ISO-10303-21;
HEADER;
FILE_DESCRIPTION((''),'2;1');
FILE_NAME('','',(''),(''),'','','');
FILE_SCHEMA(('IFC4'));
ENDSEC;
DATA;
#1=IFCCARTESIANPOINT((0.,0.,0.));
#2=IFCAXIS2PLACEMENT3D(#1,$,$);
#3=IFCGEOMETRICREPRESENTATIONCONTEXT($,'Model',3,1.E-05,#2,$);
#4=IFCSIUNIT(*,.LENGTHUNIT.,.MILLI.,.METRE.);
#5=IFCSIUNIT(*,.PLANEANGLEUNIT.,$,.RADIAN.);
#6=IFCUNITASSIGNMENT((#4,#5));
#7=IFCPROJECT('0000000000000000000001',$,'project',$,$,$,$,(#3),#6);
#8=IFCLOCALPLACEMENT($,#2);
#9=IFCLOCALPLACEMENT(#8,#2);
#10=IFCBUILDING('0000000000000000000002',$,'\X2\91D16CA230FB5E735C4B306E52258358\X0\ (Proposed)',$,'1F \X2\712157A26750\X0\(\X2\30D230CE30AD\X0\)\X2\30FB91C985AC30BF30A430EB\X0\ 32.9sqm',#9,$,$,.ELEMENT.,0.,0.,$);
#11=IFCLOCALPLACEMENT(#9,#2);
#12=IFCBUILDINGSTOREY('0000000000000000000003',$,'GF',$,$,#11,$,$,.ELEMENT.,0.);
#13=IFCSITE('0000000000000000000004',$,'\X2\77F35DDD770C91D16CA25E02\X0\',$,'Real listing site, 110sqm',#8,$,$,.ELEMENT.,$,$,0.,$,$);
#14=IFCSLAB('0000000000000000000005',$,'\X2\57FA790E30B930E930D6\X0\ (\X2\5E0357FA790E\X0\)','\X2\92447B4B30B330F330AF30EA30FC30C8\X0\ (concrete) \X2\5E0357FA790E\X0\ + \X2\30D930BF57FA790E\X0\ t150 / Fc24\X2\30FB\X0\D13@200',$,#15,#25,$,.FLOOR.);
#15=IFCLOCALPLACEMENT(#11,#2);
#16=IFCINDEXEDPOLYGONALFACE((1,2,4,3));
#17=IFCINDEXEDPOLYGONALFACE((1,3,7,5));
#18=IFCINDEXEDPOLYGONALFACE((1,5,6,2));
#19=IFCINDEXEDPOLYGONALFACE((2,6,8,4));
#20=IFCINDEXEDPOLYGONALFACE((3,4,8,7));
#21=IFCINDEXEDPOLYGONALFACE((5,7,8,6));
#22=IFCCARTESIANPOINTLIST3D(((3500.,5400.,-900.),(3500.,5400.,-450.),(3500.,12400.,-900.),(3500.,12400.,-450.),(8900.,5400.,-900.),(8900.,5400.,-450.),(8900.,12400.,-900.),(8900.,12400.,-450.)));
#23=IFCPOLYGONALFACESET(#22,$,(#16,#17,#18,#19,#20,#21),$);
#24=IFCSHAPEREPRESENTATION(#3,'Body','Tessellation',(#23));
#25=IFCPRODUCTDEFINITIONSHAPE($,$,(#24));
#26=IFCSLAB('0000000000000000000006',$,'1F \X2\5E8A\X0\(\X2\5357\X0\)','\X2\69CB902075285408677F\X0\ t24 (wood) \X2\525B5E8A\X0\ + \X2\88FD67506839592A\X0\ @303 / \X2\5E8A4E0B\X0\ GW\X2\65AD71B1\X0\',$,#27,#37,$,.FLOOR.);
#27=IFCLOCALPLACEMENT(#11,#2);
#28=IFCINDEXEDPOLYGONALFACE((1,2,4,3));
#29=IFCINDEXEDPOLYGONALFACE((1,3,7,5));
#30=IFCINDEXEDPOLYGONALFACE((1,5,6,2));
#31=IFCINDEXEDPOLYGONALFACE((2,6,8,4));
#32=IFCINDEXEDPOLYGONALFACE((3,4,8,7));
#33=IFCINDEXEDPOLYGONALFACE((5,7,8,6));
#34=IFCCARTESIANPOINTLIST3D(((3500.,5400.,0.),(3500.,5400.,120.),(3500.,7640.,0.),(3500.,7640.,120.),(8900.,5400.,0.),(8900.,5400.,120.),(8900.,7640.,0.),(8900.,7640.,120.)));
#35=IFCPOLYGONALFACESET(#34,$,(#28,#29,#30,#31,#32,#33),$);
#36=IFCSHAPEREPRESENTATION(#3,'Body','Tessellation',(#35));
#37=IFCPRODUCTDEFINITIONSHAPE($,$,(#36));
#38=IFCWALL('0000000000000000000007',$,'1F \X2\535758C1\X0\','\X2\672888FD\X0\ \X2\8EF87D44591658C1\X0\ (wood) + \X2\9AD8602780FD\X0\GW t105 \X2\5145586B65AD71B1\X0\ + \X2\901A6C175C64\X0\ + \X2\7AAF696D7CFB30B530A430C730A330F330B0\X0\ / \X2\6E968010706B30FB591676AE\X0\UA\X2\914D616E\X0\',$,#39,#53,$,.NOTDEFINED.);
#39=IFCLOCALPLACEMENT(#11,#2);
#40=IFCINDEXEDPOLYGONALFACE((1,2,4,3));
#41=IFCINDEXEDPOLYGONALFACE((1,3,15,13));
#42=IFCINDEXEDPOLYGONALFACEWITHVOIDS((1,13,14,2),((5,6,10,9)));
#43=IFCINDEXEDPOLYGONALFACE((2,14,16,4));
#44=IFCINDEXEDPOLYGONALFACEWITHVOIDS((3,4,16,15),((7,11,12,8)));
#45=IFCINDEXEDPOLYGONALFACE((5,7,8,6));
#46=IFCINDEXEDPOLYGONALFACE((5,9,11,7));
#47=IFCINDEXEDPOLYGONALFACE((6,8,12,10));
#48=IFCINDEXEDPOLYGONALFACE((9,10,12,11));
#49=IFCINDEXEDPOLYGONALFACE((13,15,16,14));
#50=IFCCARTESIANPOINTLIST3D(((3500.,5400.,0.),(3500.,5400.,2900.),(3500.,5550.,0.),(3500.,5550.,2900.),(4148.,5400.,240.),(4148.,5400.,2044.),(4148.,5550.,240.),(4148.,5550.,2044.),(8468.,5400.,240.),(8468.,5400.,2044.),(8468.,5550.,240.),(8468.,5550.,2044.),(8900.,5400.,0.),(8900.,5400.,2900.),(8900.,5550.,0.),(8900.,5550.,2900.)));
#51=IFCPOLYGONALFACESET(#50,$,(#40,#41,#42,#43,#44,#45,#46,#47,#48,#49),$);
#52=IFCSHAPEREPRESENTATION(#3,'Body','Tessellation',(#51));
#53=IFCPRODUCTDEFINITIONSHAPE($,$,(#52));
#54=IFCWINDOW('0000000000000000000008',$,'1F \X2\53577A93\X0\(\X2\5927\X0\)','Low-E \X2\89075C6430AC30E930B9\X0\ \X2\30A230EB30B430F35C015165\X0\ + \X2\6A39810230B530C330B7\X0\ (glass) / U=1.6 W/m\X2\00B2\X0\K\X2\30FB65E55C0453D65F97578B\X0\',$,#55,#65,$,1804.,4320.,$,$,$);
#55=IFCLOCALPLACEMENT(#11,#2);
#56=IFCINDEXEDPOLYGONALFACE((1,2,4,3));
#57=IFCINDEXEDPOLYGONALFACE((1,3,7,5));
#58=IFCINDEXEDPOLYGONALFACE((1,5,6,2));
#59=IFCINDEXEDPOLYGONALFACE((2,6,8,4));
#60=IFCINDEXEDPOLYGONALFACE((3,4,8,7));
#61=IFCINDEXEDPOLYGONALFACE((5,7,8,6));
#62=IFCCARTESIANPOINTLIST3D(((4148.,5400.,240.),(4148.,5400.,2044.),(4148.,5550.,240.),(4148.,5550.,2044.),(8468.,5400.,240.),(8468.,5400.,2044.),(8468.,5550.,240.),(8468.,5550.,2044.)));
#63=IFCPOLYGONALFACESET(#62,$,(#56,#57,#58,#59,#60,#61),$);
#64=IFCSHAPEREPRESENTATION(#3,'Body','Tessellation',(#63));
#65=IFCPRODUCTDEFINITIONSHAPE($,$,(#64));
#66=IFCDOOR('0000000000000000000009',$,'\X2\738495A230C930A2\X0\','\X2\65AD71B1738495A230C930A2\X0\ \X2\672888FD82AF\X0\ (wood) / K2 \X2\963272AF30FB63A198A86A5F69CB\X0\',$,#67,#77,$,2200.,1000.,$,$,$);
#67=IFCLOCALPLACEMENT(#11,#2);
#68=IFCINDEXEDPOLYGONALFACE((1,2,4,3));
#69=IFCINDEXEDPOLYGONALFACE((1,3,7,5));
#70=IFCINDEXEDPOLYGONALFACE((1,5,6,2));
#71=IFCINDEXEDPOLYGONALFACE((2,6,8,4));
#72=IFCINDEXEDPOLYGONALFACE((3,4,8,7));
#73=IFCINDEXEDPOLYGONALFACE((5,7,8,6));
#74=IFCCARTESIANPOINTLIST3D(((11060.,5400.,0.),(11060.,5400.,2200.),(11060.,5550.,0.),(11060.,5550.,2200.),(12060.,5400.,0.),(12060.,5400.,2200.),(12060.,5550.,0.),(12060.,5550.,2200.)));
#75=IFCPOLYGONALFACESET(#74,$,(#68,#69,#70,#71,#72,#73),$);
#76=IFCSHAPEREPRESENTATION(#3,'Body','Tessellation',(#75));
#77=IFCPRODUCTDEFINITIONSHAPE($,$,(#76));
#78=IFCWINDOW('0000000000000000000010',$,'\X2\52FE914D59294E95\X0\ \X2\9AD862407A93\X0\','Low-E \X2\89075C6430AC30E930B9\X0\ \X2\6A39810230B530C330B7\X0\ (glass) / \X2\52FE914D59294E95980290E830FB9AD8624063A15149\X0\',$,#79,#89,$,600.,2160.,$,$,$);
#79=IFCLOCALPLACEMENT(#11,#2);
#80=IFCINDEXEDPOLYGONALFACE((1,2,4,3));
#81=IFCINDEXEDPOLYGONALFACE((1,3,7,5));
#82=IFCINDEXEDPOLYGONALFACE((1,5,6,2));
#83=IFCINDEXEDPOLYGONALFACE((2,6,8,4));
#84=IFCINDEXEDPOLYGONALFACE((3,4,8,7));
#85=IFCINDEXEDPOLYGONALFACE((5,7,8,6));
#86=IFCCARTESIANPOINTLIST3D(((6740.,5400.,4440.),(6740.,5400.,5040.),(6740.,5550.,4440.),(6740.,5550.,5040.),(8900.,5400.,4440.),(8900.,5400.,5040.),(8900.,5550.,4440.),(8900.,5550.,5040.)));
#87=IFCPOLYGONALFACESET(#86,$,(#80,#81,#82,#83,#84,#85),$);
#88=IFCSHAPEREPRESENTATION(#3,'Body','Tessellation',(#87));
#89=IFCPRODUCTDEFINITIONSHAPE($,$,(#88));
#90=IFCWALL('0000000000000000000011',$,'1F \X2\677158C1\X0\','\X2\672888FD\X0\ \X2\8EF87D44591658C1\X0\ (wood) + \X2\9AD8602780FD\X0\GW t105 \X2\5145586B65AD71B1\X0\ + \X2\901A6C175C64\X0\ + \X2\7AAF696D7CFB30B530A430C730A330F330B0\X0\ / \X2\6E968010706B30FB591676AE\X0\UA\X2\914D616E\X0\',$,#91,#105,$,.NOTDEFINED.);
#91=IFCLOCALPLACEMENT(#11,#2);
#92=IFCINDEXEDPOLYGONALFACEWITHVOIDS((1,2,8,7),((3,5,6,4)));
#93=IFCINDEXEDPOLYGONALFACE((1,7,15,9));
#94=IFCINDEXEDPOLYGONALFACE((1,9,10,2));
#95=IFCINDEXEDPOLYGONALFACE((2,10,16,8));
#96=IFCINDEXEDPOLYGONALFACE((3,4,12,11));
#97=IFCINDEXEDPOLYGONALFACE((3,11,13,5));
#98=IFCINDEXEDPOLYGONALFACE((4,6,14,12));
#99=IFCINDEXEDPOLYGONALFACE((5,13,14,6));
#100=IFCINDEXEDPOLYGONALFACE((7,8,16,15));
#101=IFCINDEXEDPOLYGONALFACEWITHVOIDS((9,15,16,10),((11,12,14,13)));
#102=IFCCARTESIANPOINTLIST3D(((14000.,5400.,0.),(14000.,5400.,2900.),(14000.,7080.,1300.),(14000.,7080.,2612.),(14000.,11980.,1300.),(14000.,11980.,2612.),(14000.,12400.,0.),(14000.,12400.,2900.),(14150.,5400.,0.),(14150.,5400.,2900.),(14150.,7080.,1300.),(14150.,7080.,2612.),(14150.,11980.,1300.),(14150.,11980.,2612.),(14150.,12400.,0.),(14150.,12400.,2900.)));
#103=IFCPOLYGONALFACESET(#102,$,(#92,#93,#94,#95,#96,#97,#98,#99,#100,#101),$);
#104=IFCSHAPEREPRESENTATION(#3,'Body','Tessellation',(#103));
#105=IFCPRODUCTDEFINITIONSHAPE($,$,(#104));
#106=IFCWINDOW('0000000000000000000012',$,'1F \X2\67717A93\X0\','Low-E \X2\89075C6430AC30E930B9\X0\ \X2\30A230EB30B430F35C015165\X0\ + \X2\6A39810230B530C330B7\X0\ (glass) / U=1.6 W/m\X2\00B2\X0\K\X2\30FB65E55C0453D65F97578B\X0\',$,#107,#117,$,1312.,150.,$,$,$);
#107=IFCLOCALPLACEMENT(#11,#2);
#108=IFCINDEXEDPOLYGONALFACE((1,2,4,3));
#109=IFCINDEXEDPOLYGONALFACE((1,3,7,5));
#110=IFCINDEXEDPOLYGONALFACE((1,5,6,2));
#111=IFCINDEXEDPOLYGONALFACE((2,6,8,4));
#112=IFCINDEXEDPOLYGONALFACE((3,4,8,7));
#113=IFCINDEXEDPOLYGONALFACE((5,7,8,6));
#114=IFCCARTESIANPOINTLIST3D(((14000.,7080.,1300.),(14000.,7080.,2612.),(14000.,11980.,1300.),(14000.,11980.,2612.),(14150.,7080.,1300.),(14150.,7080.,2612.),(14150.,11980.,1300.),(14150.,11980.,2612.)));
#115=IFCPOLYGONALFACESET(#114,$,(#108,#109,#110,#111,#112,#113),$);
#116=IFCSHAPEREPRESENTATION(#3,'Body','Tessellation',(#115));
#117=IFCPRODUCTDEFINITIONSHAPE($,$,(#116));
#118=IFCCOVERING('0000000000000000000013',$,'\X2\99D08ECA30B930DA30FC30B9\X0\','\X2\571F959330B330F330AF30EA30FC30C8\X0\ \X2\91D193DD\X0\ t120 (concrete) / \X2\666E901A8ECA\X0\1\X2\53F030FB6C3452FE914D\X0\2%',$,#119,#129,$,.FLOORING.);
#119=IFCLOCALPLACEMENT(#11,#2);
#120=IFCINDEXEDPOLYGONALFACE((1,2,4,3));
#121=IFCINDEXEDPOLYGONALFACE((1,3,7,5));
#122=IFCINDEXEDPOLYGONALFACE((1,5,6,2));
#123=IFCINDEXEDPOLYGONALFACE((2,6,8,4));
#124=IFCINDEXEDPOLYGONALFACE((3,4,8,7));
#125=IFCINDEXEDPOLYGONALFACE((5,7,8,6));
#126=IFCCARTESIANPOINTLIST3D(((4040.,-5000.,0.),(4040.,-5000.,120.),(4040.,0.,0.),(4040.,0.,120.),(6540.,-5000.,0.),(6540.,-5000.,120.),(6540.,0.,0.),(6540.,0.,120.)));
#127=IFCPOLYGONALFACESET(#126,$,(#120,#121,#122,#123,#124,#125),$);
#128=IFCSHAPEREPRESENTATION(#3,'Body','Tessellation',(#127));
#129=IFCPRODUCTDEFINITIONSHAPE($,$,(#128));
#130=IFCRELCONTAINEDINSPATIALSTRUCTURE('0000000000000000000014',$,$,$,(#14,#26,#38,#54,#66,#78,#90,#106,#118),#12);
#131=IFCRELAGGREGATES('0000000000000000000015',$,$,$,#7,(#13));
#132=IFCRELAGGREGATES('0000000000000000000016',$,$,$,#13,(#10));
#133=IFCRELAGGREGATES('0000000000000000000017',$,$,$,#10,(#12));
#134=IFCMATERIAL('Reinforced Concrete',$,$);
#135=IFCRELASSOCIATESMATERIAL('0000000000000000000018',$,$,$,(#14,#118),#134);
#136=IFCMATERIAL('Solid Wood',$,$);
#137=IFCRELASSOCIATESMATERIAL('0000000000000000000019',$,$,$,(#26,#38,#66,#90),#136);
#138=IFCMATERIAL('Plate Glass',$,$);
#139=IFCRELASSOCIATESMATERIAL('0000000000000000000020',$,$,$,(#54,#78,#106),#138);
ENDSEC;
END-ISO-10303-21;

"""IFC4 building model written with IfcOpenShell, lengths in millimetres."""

from ifc_helpers import new_model, si_unit, frame, frame_2d, origin, place, context, project, spatial, rectangle, extrude, material, element, fill, save


model = new_model("IFC4")

# Units and contexts
model_context = context("Model", 3, precision=1e-05, world=origin())
ifc_project = project(units=[si_unit("LENGTHUNIT", "METRE", prefix="MILLI"), si_unit("PLANEANGLEUNIT", "RADIAN")], contexts=[model_context])

# Site, building, storey
site_placement = place(None, origin())
site = spatial("IfcSite", under=ifc_project, at=site_placement, Name="石川県金沢市", ObjectType="Real listing site, 110sqm", CompositionType="ELEMENT", RefElevation=0.0)
building_placement = place(site_placement, origin())
building = spatial("IfcBuilding", under=site, at=building_placement, Name="金沢・平屋の別荘 (Proposed)", ObjectType="1F 無垢材(ヒノキ)・釉薬タイル 32.9sqm", CompositionType="ELEMENT", ElevationOfRefHeight=0.0, ElevationOfTerrain=0.0)
storey_placement = place(building_placement, origin())
storey = spatial("IfcBuildingStorey", under=building, at=storey_placement, Name="GF", CompositionType="ELEMENT", Elevation=0.0)

# Shared definitions
ifc_material_1 = material(Name="Solid Wood")

# Slabs
ifc_material_2 = material(Name="Reinforced Concrete")
slab_1_placement = place(storey_placement, frame((1750.0, 2700.0, -450.0)))
element("IfcSlab", 1, at=slab_1_placement, inside=storey, material=ifc_material_2, Name="基礎スラブ (布基礎)", Description="鉄筋コンクリート (concrete) 布基礎 + ベタ基礎 t150 / Fc24・D13@200", PredefinedType="FLOOR", context=model_context, shape_type="SweptSolid", body=[
    extrude(rectangle(XDim=5400.0, YDim=7000.0, at=frame_2d((2700.0, 3500.0))), frame((1750.0, 2700.0, -450.0)), (0.0, 0.0, 1.0), 450.0),
])
slab_2_placement = place(storey_placement, frame((1750.0, 2700.0, 0.0)))
element("IfcSlab", 2, at=slab_2_placement, inside=storey, material=ifc_material_1, Name="1F 床(南)", Description="構造用合板 t24 (wood) 剛床 + 製材根太 @303 / 床下 GW断熱", PredefinedType="FLOOR", context=model_context, shape_type="SweptSolid", body=[
    extrude(rectangle(XDim=5400.0, YDim=2240.0, at=frame_2d((2700.0, 1120.0))), frame((1750.0, 2700.0, 0.0)), (0.0, 0.0, 1.0), 120.0),
])

# Wall, openings, windows, door
wall_1_placement = place(storey_placement, frame((1750.0, 2700.0, 0.0)))
wall_1 = element("IfcWall", 3, at=wall_1_placement, inside=storey, material=ifc_material_1, Name="1F 南壁", Description="木製 軸組外壁 (wood) + 高性能GW t105 充填断熱 + 通気層 + 窯業系サイディング / 準耐火・外皮UA配慮", PredefinedType="NOTDEFINED", context=model_context, shape_type="SweptSolid", body=[
    extrude(rectangle(XDim=5400.0, YDim=150.0, at=frame_2d((2700.0, 75.0))), frame((1750.0, 2700.0, 0.0)), (0.0, 0.0, 1.0), 2900.0),
])
opening_1_placement = place(storey_placement, frame((2074.0, 2700.0, 120.0)))
opening_1 = element("IfcOpeningElement", 4, at=opening_1_placement, cuts=wall_1, PredefinedType="NOTDEFINED", context=model_context, shape_type="SweptSolid", body=[
    extrude(rectangle(XDim=4320.0, YDim=150.0, at=frame_2d((2160.0, 75.0))), frame((2074.0, 2700.0, 120.0)), (0.0, 0.0, 1.0), 1804.0),
])
opening_2_placement = place(storey_placement, frame((5530.0, 2700.0, 0.0)))
opening_2 = element("IfcOpeningElement", 5, at=opening_2_placement, cuts=wall_1, PredefinedType="NOTDEFINED", context=model_context, shape_type="SweptSolid", body=[
    extrude(rectangle(XDim=1000.0, YDim=150.0, at=frame_2d((500.0, 75.0))), frame((5530.0, 2700.0, 0.0)), (0.0, 0.0, 1.0), 2200.0),
])
opening_3_placement = place(storey_placement, frame((3370.0, 2700.0, 2220.0)))
opening_3 = element("IfcOpeningElement", 6, at=opening_3_placement, cuts=wall_1, PredefinedType="NOTDEFINED", context=model_context, shape_type="SweptSolid", body=[
    extrude(rectangle(XDim=2160.0, YDim=150.0, at=frame_2d((1080.0, 75.0))), frame((3370.0, 2700.0, 2220.0)), (0.0, 0.0, 1.0), 600.0),
])
ifc_material_3 = material(Name="Plate Glass")
window_1_placement = place(storey_placement, frame((2074.0, 2700.0, 120.0)))
window_1 = element("IfcWindow", 7, at=window_1_placement, inside=storey, material=ifc_material_3, Name="1F 南窓(大)", Description="Low-E 複層ガラス アルゴン封入 + 樹脂サッシ (glass) / U=1.6 W/m²K・日射取得型", OverallHeight=1804.0, OverallWidth=4320.0, context=model_context, shape_type="SweptSolid", body=[
    extrude(rectangle(XDim=4320.0, YDim=150.0, at=frame_2d((2160.0, 75.0))), frame((2074.0, 2700.0, 120.0)), (0.0, 0.0, 1.0), 1804.0),
])
fill(opening_1, window_1)
door_placement = place(storey_placement, frame((5530.0, 2700.0, 0.0)))
door = element("IfcDoor", 8, at=door_placement, inside=storey, material=ifc_material_1, Name="玄関ドア", Description="断熱玄関ドア 木製芯 (wood) / K2 防犯・採風機構", OverallHeight=2200.0, OverallWidth=1000.0, context=model_context, shape_type="SweptSolid", body=[
    extrude(rectangle(XDim=1000.0, YDim=150.0, at=frame_2d((500.0, 75.0))), frame((5530.0, 2700.0, 0.0)), (0.0, 0.0, 1.0), 2200.0),
])
fill(opening_2, door)
window_2_placement = place(storey_placement, frame((3370.0, 2700.0, 2220.0)))
window_2 = element("IfcWindow", 9, at=window_2_placement, inside=storey, material=ifc_material_3, Name="勾配天井 高所窓", Description="Low-E 複層ガラス 樹脂サッシ (glass) / 勾配天井頂部・高所採光", OverallHeight=600.0, OverallWidth=2160.0, context=model_context, shape_type="SweptSolid", body=[
    extrude(rectangle(XDim=2160.0, YDim=150.0, at=frame_2d((1080.0, 75.0))), frame((3370.0, 2700.0, 2220.0)), (0.0, 0.0, 1.0), 600.0),
])
fill(opening_3, window_2)

# Wall, opening, window
wall_2_placement = place(storey_placement, frame((7000.0, 2700.0, 0.0)))
wall_2 = element("IfcWall", 10, at=wall_2_placement, inside=storey, material=ifc_material_1, Name="1F 東壁", Description="木製 軸組外壁 (wood) + 高性能GW t105 充填断熱 + 通気層 + 窯業系サイディング / 準耐火・外皮UA配慮", PredefinedType="NOTDEFINED", context=model_context, shape_type="SweptSolid", body=[
    extrude(rectangle(XDim=150.0, YDim=7000.0, at=frame_2d((75.0, 3500.0))), frame((7000.0, 2700.0, 0.0)), (0.0, 0.0, 1.0), 2900.0),
])
opening_4_placement = place(storey_placement, frame((7000.0, 3540.0, 650.0)))
opening_4 = element("IfcOpeningElement", 11, at=opening_4_placement, cuts=wall_2, PredefinedType="NOTDEFINED", context=model_context, shape_type="SweptSolid", body=[
    extrude(rectangle(XDim=150.0, YDim=4900.0, at=frame_2d((75.0, 2450.0))), frame((7000.0, 3540.0, 650.0)), (0.0, 0.0, 1.0), 1312.0),
])
window_3_placement = place(storey_placement, frame((7000.0, 3540.0, 650.0)))
window_3 = element("IfcWindow", 12, at=window_3_placement, inside=storey, material=ifc_material_3, Name="1F 東窓", Description="Low-E 複層ガラス アルゴン封入 + 樹脂サッシ (glass) / U=1.6 W/m²K・日射取得型", OverallHeight=1312.0, OverallWidth=150.0, context=model_context, shape_type="SweptSolid", body=[
    extrude(rectangle(XDim=150.0, YDim=4900.0, at=frame_2d((75.0, 2450.0))), frame((7000.0, 3540.0, 650.0)), (0.0, 0.0, 1.0), 1312.0),
])
fill(opening_4, window_3)

# Covering
covering_1_placement = place(storey_placement, frame((2020.0, -2500.0, 0.0)))
element("IfcCovering", 13, at=covering_1_placement, inside=storey, material=ifc_material_2, Name="駐車スペース", Description="土間コンクリート 金鏝 t120 (concrete) / 普通車1台・水勾配2%", PredefinedType="FLOORING", context=model_context, shape_type="SweptSolid", body=[
    extrude(rectangle(XDim=2500.0, YDim=5000.0, at=frame_2d((1250.0, 2500.0))), frame((2020.0, -2500.0, 0.0)), (0.0, 0.0, 1.0), 120.0),
])

save(model, "model.ifc")
